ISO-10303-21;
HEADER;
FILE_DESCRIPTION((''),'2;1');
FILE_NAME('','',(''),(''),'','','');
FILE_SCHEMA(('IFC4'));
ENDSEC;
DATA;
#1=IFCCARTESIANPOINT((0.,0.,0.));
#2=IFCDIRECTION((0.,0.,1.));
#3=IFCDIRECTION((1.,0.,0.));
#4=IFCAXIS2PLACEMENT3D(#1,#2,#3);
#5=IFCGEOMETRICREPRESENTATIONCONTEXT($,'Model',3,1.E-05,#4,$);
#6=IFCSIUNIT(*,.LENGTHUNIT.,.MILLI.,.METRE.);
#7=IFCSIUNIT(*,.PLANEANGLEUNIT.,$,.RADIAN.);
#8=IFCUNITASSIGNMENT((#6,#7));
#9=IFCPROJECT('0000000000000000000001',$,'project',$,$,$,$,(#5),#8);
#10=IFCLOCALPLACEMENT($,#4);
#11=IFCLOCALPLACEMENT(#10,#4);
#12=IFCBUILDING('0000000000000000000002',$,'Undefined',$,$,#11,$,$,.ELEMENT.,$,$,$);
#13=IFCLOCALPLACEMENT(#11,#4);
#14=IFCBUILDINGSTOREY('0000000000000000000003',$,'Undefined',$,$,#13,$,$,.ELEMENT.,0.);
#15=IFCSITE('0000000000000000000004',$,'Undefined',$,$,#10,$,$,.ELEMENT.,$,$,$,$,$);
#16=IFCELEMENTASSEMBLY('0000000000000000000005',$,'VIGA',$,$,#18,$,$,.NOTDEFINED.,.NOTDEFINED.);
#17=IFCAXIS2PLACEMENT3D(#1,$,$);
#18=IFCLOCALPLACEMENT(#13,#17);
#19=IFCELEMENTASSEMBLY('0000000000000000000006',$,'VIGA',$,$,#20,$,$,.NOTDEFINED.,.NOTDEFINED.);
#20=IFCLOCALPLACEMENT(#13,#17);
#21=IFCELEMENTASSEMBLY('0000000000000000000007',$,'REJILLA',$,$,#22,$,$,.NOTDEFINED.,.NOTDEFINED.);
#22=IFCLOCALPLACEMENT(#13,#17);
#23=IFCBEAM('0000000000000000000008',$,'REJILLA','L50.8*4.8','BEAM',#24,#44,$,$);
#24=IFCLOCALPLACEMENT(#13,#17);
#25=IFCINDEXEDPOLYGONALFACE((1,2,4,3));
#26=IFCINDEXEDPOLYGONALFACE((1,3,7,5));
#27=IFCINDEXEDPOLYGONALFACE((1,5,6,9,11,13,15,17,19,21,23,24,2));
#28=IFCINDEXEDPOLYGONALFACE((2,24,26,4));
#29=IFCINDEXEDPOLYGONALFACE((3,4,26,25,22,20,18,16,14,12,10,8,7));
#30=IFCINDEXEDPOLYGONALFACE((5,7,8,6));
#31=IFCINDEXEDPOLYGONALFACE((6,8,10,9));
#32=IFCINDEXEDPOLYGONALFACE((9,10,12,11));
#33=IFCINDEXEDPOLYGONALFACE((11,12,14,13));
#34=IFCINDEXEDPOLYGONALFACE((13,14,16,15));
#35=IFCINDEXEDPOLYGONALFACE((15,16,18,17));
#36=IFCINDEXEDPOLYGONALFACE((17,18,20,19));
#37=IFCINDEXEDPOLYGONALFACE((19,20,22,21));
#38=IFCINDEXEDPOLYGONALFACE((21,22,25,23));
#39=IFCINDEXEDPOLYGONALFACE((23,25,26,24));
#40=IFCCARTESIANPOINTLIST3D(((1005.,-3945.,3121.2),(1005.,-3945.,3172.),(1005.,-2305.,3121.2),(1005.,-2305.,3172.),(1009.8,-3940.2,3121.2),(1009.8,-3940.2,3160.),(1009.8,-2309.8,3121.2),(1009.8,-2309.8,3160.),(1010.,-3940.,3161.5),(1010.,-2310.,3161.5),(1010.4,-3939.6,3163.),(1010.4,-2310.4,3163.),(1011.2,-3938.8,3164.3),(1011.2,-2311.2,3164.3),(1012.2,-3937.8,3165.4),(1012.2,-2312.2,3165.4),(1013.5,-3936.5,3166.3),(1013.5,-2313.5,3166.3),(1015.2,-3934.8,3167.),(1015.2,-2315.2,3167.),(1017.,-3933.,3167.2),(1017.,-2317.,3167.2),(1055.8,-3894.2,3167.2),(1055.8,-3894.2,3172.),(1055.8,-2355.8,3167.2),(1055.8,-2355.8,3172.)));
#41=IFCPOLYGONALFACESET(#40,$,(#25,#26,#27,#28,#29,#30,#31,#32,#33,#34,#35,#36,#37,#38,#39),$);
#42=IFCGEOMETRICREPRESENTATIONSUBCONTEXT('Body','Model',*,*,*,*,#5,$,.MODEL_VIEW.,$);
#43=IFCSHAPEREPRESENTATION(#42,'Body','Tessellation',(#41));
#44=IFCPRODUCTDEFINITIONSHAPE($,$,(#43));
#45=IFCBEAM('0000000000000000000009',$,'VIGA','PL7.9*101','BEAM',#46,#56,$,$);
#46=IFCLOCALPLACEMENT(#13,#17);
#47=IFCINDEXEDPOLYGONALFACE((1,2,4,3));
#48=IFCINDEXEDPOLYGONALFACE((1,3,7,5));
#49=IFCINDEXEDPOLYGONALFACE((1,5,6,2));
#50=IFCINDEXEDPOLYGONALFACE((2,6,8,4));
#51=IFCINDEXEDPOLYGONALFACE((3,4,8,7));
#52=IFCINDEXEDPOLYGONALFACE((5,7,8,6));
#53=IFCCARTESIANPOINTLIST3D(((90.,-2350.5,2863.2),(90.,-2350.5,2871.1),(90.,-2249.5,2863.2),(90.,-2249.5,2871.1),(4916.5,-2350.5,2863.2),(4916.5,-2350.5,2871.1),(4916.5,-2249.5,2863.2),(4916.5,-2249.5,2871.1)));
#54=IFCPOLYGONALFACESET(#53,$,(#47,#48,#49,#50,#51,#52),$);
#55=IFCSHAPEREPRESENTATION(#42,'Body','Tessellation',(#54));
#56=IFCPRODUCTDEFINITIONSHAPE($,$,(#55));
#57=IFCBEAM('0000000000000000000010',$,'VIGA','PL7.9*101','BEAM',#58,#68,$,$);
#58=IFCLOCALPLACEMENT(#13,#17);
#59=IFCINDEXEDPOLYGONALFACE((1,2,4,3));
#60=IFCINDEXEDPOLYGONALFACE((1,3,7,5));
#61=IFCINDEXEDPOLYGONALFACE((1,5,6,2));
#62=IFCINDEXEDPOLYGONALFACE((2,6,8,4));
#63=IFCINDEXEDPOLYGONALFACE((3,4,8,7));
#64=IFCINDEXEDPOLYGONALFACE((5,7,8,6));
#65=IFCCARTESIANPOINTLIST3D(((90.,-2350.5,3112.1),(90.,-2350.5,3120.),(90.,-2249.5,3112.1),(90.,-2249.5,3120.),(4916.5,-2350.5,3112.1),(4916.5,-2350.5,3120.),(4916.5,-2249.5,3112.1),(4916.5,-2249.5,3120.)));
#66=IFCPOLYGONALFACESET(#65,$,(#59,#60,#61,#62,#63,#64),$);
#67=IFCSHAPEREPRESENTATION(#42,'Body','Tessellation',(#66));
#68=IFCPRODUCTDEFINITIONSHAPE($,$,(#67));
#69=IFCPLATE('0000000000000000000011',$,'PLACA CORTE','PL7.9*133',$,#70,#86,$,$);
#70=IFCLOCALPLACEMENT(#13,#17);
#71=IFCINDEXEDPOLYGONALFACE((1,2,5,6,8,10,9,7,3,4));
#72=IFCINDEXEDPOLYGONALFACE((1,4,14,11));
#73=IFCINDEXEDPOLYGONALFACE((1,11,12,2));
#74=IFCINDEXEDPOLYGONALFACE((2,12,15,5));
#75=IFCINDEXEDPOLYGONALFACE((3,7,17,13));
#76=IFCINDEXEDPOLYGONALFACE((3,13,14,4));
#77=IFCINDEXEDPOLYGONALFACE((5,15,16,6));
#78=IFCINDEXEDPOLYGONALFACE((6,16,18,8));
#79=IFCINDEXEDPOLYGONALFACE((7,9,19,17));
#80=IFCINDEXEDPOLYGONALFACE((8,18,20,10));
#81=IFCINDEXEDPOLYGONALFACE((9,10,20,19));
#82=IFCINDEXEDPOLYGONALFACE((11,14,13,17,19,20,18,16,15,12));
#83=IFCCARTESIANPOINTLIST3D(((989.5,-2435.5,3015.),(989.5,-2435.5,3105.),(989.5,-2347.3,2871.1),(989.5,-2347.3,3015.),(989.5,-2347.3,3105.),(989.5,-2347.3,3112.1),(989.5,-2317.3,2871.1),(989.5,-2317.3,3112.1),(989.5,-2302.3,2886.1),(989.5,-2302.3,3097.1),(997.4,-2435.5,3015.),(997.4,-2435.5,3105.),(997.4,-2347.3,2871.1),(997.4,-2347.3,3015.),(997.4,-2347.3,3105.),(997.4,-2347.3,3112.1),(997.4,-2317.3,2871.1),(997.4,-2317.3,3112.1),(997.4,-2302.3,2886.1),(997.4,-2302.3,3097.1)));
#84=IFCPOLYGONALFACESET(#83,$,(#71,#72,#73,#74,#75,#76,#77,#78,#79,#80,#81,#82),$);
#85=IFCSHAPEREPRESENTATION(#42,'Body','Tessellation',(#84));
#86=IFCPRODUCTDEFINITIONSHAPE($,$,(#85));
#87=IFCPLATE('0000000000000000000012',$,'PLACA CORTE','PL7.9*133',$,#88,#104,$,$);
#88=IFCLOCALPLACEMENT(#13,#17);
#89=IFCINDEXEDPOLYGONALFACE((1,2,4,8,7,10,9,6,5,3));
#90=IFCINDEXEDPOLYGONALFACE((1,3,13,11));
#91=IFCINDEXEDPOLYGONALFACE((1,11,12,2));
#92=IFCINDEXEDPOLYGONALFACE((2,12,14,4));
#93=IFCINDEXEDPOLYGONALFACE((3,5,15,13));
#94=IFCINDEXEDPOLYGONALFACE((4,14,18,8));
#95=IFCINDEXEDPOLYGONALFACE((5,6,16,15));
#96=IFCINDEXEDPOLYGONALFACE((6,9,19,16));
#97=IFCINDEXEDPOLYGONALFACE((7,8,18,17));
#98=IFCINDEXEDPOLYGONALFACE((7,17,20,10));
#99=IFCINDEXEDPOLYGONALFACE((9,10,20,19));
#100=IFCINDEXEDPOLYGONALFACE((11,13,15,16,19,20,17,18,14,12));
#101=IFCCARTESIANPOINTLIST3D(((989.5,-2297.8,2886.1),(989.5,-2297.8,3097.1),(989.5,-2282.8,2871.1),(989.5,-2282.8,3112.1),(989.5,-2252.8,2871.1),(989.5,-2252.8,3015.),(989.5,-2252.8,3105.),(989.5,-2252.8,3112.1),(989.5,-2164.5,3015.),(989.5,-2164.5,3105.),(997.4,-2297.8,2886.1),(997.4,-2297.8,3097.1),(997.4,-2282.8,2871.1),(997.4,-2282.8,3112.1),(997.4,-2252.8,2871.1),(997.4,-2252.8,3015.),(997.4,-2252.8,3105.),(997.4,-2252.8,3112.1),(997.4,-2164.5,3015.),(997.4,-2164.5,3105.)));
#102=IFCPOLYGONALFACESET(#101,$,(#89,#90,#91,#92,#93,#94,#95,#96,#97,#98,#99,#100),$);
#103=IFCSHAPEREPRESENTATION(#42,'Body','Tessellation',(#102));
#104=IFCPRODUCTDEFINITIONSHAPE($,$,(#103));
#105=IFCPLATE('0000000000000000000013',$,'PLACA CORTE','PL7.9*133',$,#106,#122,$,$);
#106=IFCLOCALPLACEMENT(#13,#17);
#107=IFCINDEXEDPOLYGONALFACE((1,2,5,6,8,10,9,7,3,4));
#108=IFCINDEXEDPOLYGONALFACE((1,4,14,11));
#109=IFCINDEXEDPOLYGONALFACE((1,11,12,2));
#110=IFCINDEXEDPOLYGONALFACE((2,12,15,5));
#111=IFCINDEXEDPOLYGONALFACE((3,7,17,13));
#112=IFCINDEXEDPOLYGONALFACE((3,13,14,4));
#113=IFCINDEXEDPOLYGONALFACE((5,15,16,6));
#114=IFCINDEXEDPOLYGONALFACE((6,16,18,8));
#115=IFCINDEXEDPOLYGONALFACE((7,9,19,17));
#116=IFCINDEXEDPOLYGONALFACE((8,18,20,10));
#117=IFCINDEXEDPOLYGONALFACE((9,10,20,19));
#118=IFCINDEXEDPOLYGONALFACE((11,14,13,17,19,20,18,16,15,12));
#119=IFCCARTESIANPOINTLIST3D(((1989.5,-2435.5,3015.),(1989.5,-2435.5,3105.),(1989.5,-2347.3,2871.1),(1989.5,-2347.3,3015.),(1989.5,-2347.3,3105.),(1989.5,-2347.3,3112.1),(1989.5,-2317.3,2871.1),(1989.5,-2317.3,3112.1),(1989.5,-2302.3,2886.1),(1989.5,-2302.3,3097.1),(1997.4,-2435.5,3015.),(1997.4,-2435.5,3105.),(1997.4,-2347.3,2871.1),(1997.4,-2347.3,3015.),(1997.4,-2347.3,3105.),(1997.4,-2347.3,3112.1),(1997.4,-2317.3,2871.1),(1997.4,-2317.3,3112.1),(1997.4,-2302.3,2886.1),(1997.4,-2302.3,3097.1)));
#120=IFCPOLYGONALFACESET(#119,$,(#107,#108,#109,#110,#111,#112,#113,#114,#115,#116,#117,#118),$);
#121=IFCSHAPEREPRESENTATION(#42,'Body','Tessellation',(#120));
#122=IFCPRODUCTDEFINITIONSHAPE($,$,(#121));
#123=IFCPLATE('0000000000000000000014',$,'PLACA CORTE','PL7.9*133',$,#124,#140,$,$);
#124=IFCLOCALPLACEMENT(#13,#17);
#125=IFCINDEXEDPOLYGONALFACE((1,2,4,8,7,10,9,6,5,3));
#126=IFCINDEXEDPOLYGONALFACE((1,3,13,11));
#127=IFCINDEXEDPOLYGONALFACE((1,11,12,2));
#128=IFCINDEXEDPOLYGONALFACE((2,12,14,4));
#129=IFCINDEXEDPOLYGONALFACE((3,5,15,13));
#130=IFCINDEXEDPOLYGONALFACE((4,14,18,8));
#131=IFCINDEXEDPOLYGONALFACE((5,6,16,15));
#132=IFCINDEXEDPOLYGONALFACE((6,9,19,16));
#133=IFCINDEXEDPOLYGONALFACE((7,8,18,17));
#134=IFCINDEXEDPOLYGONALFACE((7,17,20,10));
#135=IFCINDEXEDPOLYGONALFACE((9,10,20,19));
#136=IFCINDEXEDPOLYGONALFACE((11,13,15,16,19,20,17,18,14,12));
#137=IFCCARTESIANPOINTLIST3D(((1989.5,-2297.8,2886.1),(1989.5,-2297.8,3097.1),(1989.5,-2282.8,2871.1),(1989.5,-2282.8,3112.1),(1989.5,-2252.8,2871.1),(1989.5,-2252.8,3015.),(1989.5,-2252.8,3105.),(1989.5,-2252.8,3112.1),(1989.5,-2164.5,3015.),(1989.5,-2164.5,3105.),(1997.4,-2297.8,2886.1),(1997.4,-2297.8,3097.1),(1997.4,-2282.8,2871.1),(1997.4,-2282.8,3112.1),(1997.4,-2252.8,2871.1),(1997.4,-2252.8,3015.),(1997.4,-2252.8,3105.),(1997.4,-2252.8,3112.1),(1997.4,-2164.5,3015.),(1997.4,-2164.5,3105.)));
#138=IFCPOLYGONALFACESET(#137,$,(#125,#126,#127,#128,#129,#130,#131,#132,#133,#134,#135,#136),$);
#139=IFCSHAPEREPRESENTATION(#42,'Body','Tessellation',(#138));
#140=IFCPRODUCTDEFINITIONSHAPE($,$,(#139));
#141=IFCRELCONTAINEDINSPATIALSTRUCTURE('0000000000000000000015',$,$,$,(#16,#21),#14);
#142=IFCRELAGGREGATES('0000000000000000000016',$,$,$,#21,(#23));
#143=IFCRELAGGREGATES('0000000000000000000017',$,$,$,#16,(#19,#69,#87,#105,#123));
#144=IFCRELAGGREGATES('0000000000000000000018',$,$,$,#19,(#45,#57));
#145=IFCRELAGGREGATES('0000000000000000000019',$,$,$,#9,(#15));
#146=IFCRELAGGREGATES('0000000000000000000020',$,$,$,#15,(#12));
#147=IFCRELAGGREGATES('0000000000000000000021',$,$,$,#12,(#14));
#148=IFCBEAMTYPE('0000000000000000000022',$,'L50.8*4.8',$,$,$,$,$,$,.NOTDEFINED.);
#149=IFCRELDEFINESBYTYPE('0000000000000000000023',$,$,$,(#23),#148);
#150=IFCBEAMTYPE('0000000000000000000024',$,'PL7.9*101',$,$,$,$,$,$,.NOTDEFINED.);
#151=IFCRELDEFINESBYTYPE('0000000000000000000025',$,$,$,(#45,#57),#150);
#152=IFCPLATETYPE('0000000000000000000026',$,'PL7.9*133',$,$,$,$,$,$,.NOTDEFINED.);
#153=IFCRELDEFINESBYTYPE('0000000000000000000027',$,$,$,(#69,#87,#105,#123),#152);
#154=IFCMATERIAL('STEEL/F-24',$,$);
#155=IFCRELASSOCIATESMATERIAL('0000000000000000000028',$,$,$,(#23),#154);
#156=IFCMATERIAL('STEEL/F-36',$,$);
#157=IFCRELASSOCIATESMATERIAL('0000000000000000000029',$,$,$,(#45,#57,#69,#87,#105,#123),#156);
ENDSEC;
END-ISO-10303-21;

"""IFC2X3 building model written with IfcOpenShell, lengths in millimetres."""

from ifc_helpers import new_model, si_unit, frame, origin_with_axes, origin_2d_with_axis, place, context, subcontext, project, spatial, polyline, rectangle, l_section, outline, extrude, clip, halfspace, material, type_object, element, aggregate, save


model = new_model("IFC2X3")

# Units and contexts
model_context = context("Model", 3, precision=1e-05, world=origin_with_axes())
body_context = subcontext(model_context, "Body", "Model", "MODEL_VIEW")
ifc_project = project(units=[si_unit("LENGTHUNIT", "METRE", prefix="MILLI"), si_unit("PLANEANGLEUNIT", "RADIAN")], contexts=[model_context])

# Site, building, storey
site_placement = place(None, origin_with_axes())
site = spatial("IfcSite", under=ifc_project, at=site_placement, Name="Undefined", CompositionType="ELEMENT")
building_placement = place(site_placement, origin_with_axes())
building = spatial("IfcBuilding", under=site, at=building_placement, Name="Undefined", CompositionType="ELEMENT")
storey_placement = place(building_placement, origin_with_axes())
storey = spatial("IfcBuildingStorey", under=building, at=storey_placement, Name="Undefined", CompositionType="ELEMENT", Elevation=0.0)

# Element assemblies
assembly_1_placement = place(storey_placement, origin_with_axes())
assembly_1 = element("IfcElementAssembly", 1, at=assembly_1_placement, inside=storey, Name="VIGA", AssemblyPlace="NOTDEFINED", PredefinedType="NOTDEFINED")
assembly_2_placement = place(assembly_1_placement, origin_with_axes())
assembly_2 = element("IfcElementAssembly", 2, at=assembly_2_placement, Name="VIGA", AssemblyPlace="NOTDEFINED", PredefinedType="NOTDEFINED")

# Shared definitions
ifc_material_1 = material(Name="STEEL/F-36")

# Element assembly
assembly_3_placement = place(storey_placement, origin_with_axes())
assembly_3 = element("IfcElementAssembly", 3, at=assembly_3_placement, inside=storey, Name="REJILLA", AssemblyPlace="NOTDEFINED", PredefinedType="NOTDEFINED")
ifc_material_2 = material(Name="STEEL/F-24")
beam_type_1 = type_object("IfcBeamType", Name="L50.8*4.8", PredefinedType="NOTDEFINED")

# Beams
beam_1_placement = place(assembly_3_placement, frame((1030.4, -2305.0, 3146.6), z_axis=(0.0, 0.0, -1.0), x_axis=(0.0, -1.0, 0.0)))
beam_1 = element("IfcBeam", 4, at=beam_1_placement, type_object=beam_type_1, material=ifc_material_2, Name="REJILLA", Description="L50.8*4.8", ObjectType="BEAM", context=body_context, shape_type="Clipping", body=[
    clip(clip(extrude(l_section(Depth=50.8, Width=50.8, Thickness=4.8, FilletRadius=7.2, at=origin_2d_with_axis()), frame((1665.9, 0.0, 0.0), z_axis=(-1.0, 0.0, 0.0), x_axis=(0.0, -1.0, 0.0)), (0.0, 0.0, 1.0), 1691.8), halfspace(frame((1589.2, -25.4, 0.0), z_axis=(-0.707107, 0.707107, 0.0), x_axis=(0.0, 0.0, -1.0)), True)), halfspace(frame((50.8, -25.4, 0.0), z_axis=(-0.707107, -0.707107, 0.0), x_axis=(0.0, 0.0, -1.0)), False)),
])
aggregate(assembly_3, [beam_1])
beam_type_2 = type_object("IfcBeamType", Name="PL7.9*101", PredefinedType="NOTDEFINED")
beam_2_placement = place(assembly_2_placement, frame((90.0, -2300.0, 2867.1), z_axis=(0.0, 1.0, 0.0), x_axis=(1.0, 0.0, 0.0)))
beam_2 = element("IfcBeam", 5, at=beam_2_placement, type_object=beam_type_2, material=ifc_material_1, Name="VIGA", Description="PL7.9*101", ObjectType="BEAM", context=body_context, shape_type="SweptSolid", body=[
    extrude(rectangle(XDim=7.9, YDim=101.0, at=origin_2d_with_axis()), frame((4826.5, 0.0, 0.0), z_axis=(-1.0, 0.0, 0.0), x_axis=(0.0, -1.0, 0.0)), (0.0, 0.0, 1.0), 4826.5),
])
beam_3_placement = place(assembly_2_placement, frame((90.0, -2300.0, 3116.0), z_axis=(0.0, 1.0, 0.0), x_axis=(1.0, 0.0, 0.0)))
beam_3 = element("IfcBeam", 6, at=beam_3_placement, type_object=beam_type_2, material=ifc_material_1, Name="VIGA", Description="PL7.9*101", ObjectType="BEAM", context=body_context, shape_type="SweptSolid", body=[
    extrude(rectangle(XDim=7.9, YDim=101.0, at=origin_2d_with_axis()), frame((4826.5, 0.0, 0.0), z_axis=(-1.0, 0.0, 0.0), x_axis=(0.0, -1.0, 0.0)), (0.0, 0.0, 1.0), 4826.5),
])

# Plates
plate_type = type_object("IfcPlateType", Name="PL7.9*133", PredefinedType="NOTDEFINED")
plate_1_placement = place(assembly_1_placement, frame((993.5, -2302.3, 2871.1), z_axis=(-1.0, 0.0, 0.0), x_axis=(0.0, -1.0, 0.0)))
plate_1 = element("IfcPlate", 7, at=plate_1_placement, type_object=plate_type, material=ifc_material_1, Name="PLACA CORTE", Description="PL7.9*133", context=body_context, shape_type="SweptSolid", body=[
    extrude(outline(polyline([(0.0, 15.0), (15.0, 0.0), (45.0, 0.0), (45.0, 143.9), (133.2, 143.9), (133.2, 233.9), (45.0, 233.9), (45.0, 241.0), (15.0, 241.0), (0.0, 226.0), (0.0, 15.0)])), frame((0.0, 0.0, -4.0), z_axis=(0.0, 0.0, 1.0), x_axis=(1.0, 0.0, 0.0)), (0.0, 0.0, 1.0), 7.9),
])
plate_2_placement = place(assembly_1_placement, frame((993.5, -2297.8, 2871.1), z_axis=(1.0, 0.0, 0.0), x_axis=(0.0, 1.0, 0.0)))
plate_2 = element("IfcPlate", 8, at=plate_2_placement, type_object=plate_type, material=ifc_material_1, Name="PLACA CORTE", Description="PL7.9*133", context=body_context, shape_type="SweptSolid", body=[
    extrude(outline(polyline([(0.0, 15.0), (15.0, 0.0), (45.0, 0.0), (45.0, 143.9), (133.2, 143.9), (133.2, 233.9), (45.0, 233.9), (45.0, 241.0), (15.0, 241.0), (0.0, 226.0), (0.0, 15.0)])), frame((0.0, 0.0, -4.0), z_axis=(0.0, 0.0, 1.0), x_axis=(1.0, 0.0, 0.0)), (0.0, 0.0, 1.0), 7.9),
])
plate_3_placement = place(assembly_1_placement, frame((1993.5, -2302.3, 2871.1), z_axis=(-1.0, 0.0, 0.0), x_axis=(0.0, -1.0, 0.0)))
plate_3 = element("IfcPlate", 9, at=plate_3_placement, type_object=plate_type, material=ifc_material_1, Name="PLACA CORTE", Description="PL7.9*133", context=body_context, shape_type="SweptSolid", body=[
    extrude(outline(polyline([(0.0, 15.0), (15.0, 0.0), (45.0, 0.0), (45.0, 143.9), (133.2, 143.9), (133.2, 233.9), (45.0, 233.9), (45.0, 241.0), (15.0, 241.0), (0.0, 226.0), (0.0, 15.0)])), frame((0.0, 0.0, -4.0), z_axis=(0.0, 0.0, 1.0), x_axis=(1.0, 0.0, 0.0)), (0.0, 0.0, 1.0), 7.9),
])
plate_4_placement = place(assembly_1_placement, frame((1993.5, -2297.8, 2871.1), z_axis=(1.0, 0.0, 0.0), x_axis=(0.0, 1.0, 0.0)))
plate_4 = element("IfcPlate", 10, at=plate_4_placement, type_object=plate_type, material=ifc_material_1, Name="PLACA CORTE", Description="PL7.9*133", context=body_context, shape_type="SweptSolid", body=[
    extrude(outline(polyline([(0.0, 15.0), (15.0, 0.0), (45.0, 0.0), (45.0, 143.9), (133.2, 143.9), (133.2, 233.9), (45.0, 233.9), (45.0, 241.0), (15.0, 241.0), (0.0, 226.0), (0.0, 15.0)])), frame((0.0, 0.0, -4.0), z_axis=(0.0, 0.0, 1.0), x_axis=(1.0, 0.0, 0.0)), (0.0, 0.0, 1.0), 7.9),
])
aggregate(assembly_1, [assembly_2, plate_1, plate_2, plate_3, plate_4])

aggregate(assembly_2, [beam_2, beam_3])

save(model, "model.ifc")
